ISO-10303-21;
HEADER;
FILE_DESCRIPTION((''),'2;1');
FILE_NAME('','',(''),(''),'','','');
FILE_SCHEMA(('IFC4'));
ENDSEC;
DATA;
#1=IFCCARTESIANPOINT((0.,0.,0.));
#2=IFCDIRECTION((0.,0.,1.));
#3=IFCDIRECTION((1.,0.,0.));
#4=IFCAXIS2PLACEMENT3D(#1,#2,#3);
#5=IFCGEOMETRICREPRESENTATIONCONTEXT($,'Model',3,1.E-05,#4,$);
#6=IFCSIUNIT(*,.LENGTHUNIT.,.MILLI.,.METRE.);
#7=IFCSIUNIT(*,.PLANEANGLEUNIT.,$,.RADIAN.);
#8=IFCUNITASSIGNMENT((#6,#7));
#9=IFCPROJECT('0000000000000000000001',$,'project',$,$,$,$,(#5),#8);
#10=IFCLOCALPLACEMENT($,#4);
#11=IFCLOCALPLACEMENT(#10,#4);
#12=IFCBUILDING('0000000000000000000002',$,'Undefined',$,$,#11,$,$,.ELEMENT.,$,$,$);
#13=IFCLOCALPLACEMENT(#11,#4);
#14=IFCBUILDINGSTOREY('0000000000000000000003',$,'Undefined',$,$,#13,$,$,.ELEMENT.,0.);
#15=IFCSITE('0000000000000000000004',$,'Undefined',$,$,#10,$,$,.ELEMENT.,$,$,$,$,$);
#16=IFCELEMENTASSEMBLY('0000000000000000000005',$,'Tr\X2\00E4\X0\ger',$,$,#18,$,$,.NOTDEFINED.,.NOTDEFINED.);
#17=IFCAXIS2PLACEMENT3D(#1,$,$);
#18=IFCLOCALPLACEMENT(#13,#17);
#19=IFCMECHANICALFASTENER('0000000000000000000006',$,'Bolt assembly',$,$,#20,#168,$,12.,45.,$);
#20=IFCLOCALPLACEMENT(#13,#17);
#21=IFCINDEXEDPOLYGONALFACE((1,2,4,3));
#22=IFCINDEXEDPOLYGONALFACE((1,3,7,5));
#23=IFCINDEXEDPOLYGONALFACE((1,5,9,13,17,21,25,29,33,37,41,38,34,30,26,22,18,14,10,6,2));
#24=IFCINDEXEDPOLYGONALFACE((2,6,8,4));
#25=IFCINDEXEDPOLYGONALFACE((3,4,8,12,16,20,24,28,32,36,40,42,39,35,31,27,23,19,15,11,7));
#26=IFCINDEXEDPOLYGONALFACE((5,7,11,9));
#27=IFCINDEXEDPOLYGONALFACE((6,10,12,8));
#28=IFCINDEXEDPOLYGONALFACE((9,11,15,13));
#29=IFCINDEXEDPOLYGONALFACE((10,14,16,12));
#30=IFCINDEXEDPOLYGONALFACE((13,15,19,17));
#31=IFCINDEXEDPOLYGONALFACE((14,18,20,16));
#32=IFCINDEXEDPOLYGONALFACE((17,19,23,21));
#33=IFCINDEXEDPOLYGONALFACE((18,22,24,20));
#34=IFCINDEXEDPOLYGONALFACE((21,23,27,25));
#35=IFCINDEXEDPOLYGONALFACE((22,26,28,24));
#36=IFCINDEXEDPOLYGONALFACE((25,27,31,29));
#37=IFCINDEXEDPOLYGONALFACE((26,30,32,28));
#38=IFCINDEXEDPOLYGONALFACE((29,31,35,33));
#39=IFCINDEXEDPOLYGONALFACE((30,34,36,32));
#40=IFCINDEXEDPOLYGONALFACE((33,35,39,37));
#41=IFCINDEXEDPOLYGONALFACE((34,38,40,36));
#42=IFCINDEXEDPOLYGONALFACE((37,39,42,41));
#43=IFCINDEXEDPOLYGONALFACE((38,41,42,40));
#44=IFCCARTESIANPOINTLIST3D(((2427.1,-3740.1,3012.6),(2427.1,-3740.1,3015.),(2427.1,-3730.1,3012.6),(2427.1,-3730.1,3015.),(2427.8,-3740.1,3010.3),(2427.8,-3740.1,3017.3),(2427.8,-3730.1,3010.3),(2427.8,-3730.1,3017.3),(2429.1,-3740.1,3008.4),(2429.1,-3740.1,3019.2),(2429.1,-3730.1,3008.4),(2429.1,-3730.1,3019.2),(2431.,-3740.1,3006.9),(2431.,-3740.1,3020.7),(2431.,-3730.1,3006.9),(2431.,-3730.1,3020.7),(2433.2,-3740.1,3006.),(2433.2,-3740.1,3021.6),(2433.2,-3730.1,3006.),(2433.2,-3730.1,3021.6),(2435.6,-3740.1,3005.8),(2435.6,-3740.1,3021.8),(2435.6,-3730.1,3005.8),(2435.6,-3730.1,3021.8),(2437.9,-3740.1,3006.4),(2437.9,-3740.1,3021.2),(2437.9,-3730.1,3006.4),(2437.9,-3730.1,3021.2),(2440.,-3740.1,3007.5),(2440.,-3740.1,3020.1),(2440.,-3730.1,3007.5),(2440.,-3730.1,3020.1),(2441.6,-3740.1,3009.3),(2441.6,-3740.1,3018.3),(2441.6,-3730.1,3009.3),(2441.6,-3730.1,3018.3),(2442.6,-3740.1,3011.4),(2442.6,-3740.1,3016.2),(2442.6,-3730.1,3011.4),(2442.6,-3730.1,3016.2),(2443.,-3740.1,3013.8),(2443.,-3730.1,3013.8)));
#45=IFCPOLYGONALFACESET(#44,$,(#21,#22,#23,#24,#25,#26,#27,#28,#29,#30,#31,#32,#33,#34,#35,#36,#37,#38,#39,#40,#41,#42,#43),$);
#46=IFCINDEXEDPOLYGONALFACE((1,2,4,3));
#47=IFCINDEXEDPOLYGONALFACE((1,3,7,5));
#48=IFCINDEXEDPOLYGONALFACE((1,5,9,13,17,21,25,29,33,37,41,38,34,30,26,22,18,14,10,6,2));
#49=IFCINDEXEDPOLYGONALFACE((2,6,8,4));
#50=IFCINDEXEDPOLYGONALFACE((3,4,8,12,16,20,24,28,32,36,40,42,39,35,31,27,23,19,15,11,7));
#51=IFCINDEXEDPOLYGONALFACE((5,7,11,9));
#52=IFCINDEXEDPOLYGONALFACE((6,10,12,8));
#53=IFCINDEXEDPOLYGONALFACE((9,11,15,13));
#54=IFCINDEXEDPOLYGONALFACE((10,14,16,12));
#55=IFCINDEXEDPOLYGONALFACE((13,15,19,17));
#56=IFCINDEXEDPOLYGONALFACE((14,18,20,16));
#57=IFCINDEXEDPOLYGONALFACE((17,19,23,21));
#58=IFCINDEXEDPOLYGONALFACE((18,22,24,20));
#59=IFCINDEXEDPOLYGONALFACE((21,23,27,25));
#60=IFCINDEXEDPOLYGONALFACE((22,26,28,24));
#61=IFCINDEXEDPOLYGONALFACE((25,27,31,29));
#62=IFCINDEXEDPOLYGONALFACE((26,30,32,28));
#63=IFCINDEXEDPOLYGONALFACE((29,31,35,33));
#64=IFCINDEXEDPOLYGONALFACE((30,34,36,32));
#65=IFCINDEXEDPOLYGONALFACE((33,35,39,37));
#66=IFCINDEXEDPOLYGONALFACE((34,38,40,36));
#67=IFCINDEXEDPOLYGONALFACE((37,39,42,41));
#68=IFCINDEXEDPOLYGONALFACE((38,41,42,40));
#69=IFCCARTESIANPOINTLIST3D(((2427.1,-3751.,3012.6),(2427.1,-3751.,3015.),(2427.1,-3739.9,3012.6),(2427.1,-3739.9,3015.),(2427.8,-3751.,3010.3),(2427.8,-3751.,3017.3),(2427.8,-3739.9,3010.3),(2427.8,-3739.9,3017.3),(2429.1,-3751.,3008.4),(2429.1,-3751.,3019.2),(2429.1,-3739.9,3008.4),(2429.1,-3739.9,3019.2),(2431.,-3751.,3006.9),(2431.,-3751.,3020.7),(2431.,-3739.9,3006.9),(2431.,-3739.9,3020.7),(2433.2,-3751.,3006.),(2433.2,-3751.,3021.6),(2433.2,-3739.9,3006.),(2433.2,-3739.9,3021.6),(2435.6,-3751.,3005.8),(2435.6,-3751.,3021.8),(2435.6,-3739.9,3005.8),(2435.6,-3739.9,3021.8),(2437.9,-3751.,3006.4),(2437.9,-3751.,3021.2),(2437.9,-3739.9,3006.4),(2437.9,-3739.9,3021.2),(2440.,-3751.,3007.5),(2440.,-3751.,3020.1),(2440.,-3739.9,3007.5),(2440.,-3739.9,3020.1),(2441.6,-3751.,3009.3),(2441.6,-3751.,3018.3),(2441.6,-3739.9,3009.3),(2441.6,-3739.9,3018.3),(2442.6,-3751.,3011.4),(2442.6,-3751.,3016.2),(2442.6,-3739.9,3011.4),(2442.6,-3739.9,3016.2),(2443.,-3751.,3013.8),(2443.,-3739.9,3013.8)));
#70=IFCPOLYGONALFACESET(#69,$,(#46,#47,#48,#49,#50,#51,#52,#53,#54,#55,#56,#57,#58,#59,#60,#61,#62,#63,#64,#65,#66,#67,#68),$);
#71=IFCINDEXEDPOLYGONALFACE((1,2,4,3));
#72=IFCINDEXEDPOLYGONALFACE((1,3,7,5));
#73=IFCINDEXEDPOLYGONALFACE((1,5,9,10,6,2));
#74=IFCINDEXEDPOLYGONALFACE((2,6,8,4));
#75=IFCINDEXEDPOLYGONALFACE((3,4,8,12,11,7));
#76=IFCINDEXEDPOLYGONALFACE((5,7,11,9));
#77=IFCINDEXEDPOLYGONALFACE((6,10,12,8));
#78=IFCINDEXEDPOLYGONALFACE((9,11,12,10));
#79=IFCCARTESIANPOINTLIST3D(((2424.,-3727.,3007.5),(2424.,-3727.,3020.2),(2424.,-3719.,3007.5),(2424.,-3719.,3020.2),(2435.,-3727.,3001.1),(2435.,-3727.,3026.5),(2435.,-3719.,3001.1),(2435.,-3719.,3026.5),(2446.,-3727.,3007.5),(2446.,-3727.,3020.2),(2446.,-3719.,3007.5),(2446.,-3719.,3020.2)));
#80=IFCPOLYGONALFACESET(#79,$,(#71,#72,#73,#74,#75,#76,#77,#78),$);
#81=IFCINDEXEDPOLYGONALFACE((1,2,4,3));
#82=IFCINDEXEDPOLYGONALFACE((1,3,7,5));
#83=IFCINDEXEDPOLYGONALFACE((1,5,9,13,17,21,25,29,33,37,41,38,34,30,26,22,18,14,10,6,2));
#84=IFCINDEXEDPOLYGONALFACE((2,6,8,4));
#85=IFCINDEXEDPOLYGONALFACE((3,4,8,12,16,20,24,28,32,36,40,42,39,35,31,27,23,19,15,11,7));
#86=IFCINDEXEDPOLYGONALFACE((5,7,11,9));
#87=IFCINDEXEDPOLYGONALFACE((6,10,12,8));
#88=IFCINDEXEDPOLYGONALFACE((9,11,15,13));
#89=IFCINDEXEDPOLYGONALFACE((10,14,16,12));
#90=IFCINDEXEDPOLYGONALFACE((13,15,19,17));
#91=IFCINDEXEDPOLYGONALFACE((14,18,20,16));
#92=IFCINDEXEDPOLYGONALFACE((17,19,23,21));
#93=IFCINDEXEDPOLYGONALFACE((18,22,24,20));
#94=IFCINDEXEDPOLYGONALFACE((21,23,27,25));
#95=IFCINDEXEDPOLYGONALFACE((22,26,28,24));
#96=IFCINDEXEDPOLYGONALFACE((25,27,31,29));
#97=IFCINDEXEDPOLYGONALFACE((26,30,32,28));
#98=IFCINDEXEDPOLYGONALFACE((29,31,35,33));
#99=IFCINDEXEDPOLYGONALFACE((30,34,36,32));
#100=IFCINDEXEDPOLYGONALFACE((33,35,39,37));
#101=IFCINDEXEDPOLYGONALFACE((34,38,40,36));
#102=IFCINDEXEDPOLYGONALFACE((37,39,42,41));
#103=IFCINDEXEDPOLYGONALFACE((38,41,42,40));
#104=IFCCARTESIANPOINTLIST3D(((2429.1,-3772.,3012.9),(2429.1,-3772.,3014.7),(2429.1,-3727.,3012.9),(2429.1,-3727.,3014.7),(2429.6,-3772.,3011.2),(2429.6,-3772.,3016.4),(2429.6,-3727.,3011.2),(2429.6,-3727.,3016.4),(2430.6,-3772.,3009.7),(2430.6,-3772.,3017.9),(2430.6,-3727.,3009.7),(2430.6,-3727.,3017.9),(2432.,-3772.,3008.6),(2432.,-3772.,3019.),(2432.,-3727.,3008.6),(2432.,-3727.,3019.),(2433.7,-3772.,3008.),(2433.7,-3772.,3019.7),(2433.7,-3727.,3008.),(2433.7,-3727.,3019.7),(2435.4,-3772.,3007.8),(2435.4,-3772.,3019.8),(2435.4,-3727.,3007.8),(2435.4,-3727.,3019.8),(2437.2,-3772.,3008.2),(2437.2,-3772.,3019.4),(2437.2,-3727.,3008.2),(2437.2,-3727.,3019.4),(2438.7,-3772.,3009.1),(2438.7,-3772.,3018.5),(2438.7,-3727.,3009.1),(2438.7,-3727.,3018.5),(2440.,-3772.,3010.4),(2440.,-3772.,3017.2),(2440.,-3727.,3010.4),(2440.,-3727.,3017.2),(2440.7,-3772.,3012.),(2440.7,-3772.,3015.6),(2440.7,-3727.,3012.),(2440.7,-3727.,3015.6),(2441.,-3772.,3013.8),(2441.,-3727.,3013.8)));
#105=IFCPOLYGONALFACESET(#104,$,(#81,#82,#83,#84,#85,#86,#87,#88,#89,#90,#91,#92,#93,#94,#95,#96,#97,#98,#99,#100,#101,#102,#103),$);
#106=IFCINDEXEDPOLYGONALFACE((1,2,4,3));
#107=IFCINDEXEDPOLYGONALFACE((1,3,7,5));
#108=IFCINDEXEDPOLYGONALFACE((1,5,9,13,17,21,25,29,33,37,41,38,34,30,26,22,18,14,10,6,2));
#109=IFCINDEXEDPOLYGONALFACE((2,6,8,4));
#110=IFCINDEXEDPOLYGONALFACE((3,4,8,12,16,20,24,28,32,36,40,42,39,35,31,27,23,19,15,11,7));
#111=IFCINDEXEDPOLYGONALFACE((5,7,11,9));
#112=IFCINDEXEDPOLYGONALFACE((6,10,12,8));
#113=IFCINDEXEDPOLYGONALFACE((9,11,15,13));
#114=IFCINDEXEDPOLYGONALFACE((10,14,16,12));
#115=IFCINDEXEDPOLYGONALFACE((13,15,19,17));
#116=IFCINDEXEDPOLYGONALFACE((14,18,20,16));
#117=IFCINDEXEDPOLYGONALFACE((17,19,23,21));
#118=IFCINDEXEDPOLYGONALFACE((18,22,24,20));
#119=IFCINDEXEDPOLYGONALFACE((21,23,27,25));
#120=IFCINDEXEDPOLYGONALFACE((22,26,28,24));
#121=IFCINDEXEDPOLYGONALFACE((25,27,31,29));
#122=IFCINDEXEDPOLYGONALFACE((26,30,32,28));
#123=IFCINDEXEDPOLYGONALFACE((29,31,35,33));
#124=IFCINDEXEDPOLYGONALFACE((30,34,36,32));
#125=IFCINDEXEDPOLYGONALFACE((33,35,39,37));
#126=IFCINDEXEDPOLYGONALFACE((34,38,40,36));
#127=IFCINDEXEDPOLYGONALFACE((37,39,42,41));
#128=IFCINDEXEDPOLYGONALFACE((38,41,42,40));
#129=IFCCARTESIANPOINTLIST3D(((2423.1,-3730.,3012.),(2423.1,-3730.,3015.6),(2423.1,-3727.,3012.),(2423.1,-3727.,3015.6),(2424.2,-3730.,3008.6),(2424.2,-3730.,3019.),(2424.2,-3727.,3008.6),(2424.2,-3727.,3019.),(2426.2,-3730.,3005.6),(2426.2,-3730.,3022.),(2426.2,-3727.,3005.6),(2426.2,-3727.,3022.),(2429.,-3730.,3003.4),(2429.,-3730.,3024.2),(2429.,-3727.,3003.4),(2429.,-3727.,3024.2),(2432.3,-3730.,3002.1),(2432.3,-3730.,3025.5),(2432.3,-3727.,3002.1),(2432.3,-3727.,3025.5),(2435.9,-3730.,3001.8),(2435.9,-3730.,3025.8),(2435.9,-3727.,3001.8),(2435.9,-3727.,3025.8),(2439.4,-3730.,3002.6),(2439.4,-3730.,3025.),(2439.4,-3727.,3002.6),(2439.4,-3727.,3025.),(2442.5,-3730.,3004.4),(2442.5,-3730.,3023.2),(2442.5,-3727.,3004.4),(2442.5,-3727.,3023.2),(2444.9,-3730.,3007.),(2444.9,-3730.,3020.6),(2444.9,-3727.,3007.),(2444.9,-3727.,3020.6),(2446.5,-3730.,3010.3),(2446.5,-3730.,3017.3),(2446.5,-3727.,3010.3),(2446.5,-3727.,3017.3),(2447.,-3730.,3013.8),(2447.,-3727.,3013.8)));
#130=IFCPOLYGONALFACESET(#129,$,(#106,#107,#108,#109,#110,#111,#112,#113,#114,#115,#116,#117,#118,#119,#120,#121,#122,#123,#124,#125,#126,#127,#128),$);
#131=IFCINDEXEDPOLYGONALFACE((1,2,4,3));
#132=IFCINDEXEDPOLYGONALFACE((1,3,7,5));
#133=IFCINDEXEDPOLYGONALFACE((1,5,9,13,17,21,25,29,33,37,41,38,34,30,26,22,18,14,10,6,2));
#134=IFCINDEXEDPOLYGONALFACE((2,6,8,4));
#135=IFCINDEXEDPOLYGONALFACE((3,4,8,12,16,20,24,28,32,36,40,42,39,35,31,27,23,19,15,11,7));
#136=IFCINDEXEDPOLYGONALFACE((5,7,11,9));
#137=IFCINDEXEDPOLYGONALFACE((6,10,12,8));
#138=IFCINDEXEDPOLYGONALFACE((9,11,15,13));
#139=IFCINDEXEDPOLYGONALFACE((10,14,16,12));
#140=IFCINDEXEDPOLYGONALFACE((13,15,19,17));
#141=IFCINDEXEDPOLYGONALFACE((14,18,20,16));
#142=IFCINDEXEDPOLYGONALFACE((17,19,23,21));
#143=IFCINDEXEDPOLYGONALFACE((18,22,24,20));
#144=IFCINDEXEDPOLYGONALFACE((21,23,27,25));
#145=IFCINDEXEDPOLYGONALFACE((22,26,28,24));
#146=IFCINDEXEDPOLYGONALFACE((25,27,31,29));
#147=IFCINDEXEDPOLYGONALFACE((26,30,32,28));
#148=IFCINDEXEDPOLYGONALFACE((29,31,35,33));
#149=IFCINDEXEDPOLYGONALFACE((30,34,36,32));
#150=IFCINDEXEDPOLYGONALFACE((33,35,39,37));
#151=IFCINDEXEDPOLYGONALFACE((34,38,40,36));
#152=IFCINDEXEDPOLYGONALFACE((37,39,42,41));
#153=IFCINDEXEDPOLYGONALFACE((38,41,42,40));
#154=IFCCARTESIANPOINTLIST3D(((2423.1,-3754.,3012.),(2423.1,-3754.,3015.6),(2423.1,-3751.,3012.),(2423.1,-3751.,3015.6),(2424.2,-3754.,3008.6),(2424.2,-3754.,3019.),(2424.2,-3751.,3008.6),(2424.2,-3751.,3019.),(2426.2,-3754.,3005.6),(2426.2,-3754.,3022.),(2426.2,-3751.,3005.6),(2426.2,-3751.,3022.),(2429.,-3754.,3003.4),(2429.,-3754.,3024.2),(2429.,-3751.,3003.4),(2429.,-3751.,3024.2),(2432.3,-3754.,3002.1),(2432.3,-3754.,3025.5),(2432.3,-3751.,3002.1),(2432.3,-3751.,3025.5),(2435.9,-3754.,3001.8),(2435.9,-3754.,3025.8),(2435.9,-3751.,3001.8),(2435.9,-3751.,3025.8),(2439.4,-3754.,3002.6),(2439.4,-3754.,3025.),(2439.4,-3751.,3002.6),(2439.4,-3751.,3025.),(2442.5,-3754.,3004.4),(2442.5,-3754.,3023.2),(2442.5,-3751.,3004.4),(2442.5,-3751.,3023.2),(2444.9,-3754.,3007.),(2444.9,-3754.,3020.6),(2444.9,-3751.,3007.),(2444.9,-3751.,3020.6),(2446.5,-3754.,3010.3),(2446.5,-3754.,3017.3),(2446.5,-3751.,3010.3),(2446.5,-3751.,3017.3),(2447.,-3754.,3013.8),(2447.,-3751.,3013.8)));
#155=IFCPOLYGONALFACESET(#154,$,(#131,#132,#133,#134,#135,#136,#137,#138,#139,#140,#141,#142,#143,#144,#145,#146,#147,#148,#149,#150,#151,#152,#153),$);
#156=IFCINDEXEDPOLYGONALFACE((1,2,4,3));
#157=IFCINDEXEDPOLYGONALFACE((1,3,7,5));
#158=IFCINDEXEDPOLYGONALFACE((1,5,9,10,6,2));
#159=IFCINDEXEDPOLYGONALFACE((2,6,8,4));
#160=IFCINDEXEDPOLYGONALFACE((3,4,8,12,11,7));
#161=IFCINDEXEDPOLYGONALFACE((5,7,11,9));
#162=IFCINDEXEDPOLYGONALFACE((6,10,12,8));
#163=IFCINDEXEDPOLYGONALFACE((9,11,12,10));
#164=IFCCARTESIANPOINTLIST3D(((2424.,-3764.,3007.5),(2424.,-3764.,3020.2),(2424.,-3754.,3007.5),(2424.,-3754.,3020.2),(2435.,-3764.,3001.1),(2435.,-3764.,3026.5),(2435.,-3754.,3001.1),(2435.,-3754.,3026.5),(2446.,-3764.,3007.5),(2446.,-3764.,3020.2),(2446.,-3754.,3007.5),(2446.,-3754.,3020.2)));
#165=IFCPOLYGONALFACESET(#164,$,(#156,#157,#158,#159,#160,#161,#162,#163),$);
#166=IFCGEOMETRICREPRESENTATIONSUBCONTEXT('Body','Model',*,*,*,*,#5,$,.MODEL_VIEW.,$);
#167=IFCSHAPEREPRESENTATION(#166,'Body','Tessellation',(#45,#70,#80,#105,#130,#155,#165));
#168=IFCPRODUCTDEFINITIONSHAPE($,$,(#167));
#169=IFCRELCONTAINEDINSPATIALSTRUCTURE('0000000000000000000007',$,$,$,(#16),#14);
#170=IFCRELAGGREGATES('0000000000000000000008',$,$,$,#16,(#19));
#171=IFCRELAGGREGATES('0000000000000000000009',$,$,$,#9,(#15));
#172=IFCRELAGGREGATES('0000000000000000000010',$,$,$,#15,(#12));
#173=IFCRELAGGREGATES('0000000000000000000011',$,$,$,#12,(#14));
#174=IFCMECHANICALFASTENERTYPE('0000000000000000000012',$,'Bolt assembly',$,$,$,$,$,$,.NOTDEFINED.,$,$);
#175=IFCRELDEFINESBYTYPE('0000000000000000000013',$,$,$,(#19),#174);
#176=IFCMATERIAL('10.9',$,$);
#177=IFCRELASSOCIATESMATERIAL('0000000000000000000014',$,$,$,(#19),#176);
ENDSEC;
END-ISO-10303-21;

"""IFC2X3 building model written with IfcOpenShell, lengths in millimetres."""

from ifc_helpers import new_model, si_unit, frame, origin_with_axes, origin_2d_with_axis, place, context, subcontext, project, spatial, polyline, circle, outline, extrude, source, transform, mapped, material, type_object, element, aggregate, save


model = new_model("IFC2X3")

# Units and contexts
model_context = context("Model", 3, precision=1e-05, world=origin_with_axes())
body_context = subcontext(model_context, "Body", "Model", "MODEL_VIEW")
ifc_project = project(units=[si_unit("LENGTHUNIT", "METRE", prefix="MILLI"), si_unit("PLANEANGLEUNIT", "RADIAN")], contexts=[model_context])

# Site, building, storey
site_placement = place(None, origin_with_axes())
site = spatial("IfcSite", under=ifc_project, at=site_placement, Name="Undefined", CompositionType="ELEMENT")
building_placement = place(site_placement, origin_with_axes())
building = spatial("IfcBuilding", under=site, at=building_placement, Name="Undefined", CompositionType="ELEMENT")
storey_placement = place(building_placement, origin_with_axes())
storey = spatial("IfcBuildingStorey", under=building, at=storey_placement, Name="Undefined", CompositionType="ELEMENT", Elevation=0.0)

# Element assembly
assembly_1_placement = place(storey_placement, origin_with_axes())
assembly_1 = element("IfcElementAssembly", 1, at=assembly_1_placement, inside=storey, Name="Träger", AssemblyPlace="NOTDEFINED", PredefinedType="NOTDEFINED")

# Mechanical fastener
ifc_material_1 = material(Name="10.9")
mechanical_fastener_type = type_object("IfcMechanicalFastenerType", Name="Bolt assembly")
shared_shape_1 = source(origin_with_axes(), body_context, "Body", "SweptSolid", [
    extrude(circle(Radius=8.0, at=origin_2d_with_axis()), frame((0.0, 0.1, 0.0), z_axis=(0.0, 1.0, 0.0), x_axis=(1.0, 0.0, 0.0)), (0.0, 0.0, 1.0), 10.0),
    extrude(circle(Radius=8.0, at=origin_2d_with_axis()), frame((0.0, 9.9, 0.0), z_axis=(0.0, 1.0, 0.0), x_axis=(1.0, 0.0, 0.0)), (0.0, 0.0, 1.0), 11.1),
    extrude(outline(polyline([(11.0, -6.4), (11.0, 6.4), (0.0, 12.7), (-11.0, 6.4), (-11.0, -6.4), (0.0, -12.7), (11.0, -6.4)])), frame((0.0, -11.0, 0.0), z_axis=(0.0, 1.0, 0.0), x_axis=(1.0, 0.0, 0.0)), (0.0, 0.0, 1.0), 8.0),
    extrude(circle(Radius=6.0, at=origin_2d_with_axis()), frame((0.0, -3.0, 0.0), z_axis=(0.0, 1.0, 0.0), x_axis=(1.0, 0.0, 0.0)), (0.0, 0.0, 1.0), 45.0),
    extrude(circle(Radius=12.0, at=origin_2d_with_axis()), frame((0.0, -3.0, 0.0), z_axis=(0.0, 1.0, 0.0), x_axis=(1.0, 0.0, 0.0)), (0.0, 0.0, 1.0), 3.0),
    extrude(circle(Radius=12.0, at=origin_2d_with_axis()), frame((0.0, 21.0, 0.0), z_axis=(0.0, 1.0, 0.0), x_axis=(1.0, 0.0, 0.0)), (0.0, 0.0, 1.0), 3.0),
    extrude(outline(polyline([(11.0, -6.4), (11.0, 6.4), (0.0, 12.7), (-11.0, 6.4), (-11.0, -6.4), (0.0, -12.7), (11.0, -6.4)])), frame((0.0, 24.0, 0.0), z_axis=(0.0, 1.0, 0.0), x_axis=(1.0, 0.0, 0.0)), (0.0, 0.0, 1.0), 10.0),
])
mechanical_fastener_1_placement = place(assembly_1_placement, frame((2435.0, -3730.0, 3013.8), z_axis=(0.0, 0.0, -1.0), x_axis=(1.0, 0.0, 0.0)))
mechanical_fastener_1 = element("IfcMechanicalFastener", 2, at=mechanical_fastener_1_placement, type_object=mechanical_fastener_type, material=ifc_material_1, Name="Bolt assembly", NominalDiameter=12.0, NominalLength=45.0, context=body_context, shape_type="MappedRepresentation", body=[
    mapped(shared_shape_1, transform((0.0, 0.0, 0.0))),
])
aggregate(assembly_1, [mechanical_fastener_1])

save(model, "model.ifc")
